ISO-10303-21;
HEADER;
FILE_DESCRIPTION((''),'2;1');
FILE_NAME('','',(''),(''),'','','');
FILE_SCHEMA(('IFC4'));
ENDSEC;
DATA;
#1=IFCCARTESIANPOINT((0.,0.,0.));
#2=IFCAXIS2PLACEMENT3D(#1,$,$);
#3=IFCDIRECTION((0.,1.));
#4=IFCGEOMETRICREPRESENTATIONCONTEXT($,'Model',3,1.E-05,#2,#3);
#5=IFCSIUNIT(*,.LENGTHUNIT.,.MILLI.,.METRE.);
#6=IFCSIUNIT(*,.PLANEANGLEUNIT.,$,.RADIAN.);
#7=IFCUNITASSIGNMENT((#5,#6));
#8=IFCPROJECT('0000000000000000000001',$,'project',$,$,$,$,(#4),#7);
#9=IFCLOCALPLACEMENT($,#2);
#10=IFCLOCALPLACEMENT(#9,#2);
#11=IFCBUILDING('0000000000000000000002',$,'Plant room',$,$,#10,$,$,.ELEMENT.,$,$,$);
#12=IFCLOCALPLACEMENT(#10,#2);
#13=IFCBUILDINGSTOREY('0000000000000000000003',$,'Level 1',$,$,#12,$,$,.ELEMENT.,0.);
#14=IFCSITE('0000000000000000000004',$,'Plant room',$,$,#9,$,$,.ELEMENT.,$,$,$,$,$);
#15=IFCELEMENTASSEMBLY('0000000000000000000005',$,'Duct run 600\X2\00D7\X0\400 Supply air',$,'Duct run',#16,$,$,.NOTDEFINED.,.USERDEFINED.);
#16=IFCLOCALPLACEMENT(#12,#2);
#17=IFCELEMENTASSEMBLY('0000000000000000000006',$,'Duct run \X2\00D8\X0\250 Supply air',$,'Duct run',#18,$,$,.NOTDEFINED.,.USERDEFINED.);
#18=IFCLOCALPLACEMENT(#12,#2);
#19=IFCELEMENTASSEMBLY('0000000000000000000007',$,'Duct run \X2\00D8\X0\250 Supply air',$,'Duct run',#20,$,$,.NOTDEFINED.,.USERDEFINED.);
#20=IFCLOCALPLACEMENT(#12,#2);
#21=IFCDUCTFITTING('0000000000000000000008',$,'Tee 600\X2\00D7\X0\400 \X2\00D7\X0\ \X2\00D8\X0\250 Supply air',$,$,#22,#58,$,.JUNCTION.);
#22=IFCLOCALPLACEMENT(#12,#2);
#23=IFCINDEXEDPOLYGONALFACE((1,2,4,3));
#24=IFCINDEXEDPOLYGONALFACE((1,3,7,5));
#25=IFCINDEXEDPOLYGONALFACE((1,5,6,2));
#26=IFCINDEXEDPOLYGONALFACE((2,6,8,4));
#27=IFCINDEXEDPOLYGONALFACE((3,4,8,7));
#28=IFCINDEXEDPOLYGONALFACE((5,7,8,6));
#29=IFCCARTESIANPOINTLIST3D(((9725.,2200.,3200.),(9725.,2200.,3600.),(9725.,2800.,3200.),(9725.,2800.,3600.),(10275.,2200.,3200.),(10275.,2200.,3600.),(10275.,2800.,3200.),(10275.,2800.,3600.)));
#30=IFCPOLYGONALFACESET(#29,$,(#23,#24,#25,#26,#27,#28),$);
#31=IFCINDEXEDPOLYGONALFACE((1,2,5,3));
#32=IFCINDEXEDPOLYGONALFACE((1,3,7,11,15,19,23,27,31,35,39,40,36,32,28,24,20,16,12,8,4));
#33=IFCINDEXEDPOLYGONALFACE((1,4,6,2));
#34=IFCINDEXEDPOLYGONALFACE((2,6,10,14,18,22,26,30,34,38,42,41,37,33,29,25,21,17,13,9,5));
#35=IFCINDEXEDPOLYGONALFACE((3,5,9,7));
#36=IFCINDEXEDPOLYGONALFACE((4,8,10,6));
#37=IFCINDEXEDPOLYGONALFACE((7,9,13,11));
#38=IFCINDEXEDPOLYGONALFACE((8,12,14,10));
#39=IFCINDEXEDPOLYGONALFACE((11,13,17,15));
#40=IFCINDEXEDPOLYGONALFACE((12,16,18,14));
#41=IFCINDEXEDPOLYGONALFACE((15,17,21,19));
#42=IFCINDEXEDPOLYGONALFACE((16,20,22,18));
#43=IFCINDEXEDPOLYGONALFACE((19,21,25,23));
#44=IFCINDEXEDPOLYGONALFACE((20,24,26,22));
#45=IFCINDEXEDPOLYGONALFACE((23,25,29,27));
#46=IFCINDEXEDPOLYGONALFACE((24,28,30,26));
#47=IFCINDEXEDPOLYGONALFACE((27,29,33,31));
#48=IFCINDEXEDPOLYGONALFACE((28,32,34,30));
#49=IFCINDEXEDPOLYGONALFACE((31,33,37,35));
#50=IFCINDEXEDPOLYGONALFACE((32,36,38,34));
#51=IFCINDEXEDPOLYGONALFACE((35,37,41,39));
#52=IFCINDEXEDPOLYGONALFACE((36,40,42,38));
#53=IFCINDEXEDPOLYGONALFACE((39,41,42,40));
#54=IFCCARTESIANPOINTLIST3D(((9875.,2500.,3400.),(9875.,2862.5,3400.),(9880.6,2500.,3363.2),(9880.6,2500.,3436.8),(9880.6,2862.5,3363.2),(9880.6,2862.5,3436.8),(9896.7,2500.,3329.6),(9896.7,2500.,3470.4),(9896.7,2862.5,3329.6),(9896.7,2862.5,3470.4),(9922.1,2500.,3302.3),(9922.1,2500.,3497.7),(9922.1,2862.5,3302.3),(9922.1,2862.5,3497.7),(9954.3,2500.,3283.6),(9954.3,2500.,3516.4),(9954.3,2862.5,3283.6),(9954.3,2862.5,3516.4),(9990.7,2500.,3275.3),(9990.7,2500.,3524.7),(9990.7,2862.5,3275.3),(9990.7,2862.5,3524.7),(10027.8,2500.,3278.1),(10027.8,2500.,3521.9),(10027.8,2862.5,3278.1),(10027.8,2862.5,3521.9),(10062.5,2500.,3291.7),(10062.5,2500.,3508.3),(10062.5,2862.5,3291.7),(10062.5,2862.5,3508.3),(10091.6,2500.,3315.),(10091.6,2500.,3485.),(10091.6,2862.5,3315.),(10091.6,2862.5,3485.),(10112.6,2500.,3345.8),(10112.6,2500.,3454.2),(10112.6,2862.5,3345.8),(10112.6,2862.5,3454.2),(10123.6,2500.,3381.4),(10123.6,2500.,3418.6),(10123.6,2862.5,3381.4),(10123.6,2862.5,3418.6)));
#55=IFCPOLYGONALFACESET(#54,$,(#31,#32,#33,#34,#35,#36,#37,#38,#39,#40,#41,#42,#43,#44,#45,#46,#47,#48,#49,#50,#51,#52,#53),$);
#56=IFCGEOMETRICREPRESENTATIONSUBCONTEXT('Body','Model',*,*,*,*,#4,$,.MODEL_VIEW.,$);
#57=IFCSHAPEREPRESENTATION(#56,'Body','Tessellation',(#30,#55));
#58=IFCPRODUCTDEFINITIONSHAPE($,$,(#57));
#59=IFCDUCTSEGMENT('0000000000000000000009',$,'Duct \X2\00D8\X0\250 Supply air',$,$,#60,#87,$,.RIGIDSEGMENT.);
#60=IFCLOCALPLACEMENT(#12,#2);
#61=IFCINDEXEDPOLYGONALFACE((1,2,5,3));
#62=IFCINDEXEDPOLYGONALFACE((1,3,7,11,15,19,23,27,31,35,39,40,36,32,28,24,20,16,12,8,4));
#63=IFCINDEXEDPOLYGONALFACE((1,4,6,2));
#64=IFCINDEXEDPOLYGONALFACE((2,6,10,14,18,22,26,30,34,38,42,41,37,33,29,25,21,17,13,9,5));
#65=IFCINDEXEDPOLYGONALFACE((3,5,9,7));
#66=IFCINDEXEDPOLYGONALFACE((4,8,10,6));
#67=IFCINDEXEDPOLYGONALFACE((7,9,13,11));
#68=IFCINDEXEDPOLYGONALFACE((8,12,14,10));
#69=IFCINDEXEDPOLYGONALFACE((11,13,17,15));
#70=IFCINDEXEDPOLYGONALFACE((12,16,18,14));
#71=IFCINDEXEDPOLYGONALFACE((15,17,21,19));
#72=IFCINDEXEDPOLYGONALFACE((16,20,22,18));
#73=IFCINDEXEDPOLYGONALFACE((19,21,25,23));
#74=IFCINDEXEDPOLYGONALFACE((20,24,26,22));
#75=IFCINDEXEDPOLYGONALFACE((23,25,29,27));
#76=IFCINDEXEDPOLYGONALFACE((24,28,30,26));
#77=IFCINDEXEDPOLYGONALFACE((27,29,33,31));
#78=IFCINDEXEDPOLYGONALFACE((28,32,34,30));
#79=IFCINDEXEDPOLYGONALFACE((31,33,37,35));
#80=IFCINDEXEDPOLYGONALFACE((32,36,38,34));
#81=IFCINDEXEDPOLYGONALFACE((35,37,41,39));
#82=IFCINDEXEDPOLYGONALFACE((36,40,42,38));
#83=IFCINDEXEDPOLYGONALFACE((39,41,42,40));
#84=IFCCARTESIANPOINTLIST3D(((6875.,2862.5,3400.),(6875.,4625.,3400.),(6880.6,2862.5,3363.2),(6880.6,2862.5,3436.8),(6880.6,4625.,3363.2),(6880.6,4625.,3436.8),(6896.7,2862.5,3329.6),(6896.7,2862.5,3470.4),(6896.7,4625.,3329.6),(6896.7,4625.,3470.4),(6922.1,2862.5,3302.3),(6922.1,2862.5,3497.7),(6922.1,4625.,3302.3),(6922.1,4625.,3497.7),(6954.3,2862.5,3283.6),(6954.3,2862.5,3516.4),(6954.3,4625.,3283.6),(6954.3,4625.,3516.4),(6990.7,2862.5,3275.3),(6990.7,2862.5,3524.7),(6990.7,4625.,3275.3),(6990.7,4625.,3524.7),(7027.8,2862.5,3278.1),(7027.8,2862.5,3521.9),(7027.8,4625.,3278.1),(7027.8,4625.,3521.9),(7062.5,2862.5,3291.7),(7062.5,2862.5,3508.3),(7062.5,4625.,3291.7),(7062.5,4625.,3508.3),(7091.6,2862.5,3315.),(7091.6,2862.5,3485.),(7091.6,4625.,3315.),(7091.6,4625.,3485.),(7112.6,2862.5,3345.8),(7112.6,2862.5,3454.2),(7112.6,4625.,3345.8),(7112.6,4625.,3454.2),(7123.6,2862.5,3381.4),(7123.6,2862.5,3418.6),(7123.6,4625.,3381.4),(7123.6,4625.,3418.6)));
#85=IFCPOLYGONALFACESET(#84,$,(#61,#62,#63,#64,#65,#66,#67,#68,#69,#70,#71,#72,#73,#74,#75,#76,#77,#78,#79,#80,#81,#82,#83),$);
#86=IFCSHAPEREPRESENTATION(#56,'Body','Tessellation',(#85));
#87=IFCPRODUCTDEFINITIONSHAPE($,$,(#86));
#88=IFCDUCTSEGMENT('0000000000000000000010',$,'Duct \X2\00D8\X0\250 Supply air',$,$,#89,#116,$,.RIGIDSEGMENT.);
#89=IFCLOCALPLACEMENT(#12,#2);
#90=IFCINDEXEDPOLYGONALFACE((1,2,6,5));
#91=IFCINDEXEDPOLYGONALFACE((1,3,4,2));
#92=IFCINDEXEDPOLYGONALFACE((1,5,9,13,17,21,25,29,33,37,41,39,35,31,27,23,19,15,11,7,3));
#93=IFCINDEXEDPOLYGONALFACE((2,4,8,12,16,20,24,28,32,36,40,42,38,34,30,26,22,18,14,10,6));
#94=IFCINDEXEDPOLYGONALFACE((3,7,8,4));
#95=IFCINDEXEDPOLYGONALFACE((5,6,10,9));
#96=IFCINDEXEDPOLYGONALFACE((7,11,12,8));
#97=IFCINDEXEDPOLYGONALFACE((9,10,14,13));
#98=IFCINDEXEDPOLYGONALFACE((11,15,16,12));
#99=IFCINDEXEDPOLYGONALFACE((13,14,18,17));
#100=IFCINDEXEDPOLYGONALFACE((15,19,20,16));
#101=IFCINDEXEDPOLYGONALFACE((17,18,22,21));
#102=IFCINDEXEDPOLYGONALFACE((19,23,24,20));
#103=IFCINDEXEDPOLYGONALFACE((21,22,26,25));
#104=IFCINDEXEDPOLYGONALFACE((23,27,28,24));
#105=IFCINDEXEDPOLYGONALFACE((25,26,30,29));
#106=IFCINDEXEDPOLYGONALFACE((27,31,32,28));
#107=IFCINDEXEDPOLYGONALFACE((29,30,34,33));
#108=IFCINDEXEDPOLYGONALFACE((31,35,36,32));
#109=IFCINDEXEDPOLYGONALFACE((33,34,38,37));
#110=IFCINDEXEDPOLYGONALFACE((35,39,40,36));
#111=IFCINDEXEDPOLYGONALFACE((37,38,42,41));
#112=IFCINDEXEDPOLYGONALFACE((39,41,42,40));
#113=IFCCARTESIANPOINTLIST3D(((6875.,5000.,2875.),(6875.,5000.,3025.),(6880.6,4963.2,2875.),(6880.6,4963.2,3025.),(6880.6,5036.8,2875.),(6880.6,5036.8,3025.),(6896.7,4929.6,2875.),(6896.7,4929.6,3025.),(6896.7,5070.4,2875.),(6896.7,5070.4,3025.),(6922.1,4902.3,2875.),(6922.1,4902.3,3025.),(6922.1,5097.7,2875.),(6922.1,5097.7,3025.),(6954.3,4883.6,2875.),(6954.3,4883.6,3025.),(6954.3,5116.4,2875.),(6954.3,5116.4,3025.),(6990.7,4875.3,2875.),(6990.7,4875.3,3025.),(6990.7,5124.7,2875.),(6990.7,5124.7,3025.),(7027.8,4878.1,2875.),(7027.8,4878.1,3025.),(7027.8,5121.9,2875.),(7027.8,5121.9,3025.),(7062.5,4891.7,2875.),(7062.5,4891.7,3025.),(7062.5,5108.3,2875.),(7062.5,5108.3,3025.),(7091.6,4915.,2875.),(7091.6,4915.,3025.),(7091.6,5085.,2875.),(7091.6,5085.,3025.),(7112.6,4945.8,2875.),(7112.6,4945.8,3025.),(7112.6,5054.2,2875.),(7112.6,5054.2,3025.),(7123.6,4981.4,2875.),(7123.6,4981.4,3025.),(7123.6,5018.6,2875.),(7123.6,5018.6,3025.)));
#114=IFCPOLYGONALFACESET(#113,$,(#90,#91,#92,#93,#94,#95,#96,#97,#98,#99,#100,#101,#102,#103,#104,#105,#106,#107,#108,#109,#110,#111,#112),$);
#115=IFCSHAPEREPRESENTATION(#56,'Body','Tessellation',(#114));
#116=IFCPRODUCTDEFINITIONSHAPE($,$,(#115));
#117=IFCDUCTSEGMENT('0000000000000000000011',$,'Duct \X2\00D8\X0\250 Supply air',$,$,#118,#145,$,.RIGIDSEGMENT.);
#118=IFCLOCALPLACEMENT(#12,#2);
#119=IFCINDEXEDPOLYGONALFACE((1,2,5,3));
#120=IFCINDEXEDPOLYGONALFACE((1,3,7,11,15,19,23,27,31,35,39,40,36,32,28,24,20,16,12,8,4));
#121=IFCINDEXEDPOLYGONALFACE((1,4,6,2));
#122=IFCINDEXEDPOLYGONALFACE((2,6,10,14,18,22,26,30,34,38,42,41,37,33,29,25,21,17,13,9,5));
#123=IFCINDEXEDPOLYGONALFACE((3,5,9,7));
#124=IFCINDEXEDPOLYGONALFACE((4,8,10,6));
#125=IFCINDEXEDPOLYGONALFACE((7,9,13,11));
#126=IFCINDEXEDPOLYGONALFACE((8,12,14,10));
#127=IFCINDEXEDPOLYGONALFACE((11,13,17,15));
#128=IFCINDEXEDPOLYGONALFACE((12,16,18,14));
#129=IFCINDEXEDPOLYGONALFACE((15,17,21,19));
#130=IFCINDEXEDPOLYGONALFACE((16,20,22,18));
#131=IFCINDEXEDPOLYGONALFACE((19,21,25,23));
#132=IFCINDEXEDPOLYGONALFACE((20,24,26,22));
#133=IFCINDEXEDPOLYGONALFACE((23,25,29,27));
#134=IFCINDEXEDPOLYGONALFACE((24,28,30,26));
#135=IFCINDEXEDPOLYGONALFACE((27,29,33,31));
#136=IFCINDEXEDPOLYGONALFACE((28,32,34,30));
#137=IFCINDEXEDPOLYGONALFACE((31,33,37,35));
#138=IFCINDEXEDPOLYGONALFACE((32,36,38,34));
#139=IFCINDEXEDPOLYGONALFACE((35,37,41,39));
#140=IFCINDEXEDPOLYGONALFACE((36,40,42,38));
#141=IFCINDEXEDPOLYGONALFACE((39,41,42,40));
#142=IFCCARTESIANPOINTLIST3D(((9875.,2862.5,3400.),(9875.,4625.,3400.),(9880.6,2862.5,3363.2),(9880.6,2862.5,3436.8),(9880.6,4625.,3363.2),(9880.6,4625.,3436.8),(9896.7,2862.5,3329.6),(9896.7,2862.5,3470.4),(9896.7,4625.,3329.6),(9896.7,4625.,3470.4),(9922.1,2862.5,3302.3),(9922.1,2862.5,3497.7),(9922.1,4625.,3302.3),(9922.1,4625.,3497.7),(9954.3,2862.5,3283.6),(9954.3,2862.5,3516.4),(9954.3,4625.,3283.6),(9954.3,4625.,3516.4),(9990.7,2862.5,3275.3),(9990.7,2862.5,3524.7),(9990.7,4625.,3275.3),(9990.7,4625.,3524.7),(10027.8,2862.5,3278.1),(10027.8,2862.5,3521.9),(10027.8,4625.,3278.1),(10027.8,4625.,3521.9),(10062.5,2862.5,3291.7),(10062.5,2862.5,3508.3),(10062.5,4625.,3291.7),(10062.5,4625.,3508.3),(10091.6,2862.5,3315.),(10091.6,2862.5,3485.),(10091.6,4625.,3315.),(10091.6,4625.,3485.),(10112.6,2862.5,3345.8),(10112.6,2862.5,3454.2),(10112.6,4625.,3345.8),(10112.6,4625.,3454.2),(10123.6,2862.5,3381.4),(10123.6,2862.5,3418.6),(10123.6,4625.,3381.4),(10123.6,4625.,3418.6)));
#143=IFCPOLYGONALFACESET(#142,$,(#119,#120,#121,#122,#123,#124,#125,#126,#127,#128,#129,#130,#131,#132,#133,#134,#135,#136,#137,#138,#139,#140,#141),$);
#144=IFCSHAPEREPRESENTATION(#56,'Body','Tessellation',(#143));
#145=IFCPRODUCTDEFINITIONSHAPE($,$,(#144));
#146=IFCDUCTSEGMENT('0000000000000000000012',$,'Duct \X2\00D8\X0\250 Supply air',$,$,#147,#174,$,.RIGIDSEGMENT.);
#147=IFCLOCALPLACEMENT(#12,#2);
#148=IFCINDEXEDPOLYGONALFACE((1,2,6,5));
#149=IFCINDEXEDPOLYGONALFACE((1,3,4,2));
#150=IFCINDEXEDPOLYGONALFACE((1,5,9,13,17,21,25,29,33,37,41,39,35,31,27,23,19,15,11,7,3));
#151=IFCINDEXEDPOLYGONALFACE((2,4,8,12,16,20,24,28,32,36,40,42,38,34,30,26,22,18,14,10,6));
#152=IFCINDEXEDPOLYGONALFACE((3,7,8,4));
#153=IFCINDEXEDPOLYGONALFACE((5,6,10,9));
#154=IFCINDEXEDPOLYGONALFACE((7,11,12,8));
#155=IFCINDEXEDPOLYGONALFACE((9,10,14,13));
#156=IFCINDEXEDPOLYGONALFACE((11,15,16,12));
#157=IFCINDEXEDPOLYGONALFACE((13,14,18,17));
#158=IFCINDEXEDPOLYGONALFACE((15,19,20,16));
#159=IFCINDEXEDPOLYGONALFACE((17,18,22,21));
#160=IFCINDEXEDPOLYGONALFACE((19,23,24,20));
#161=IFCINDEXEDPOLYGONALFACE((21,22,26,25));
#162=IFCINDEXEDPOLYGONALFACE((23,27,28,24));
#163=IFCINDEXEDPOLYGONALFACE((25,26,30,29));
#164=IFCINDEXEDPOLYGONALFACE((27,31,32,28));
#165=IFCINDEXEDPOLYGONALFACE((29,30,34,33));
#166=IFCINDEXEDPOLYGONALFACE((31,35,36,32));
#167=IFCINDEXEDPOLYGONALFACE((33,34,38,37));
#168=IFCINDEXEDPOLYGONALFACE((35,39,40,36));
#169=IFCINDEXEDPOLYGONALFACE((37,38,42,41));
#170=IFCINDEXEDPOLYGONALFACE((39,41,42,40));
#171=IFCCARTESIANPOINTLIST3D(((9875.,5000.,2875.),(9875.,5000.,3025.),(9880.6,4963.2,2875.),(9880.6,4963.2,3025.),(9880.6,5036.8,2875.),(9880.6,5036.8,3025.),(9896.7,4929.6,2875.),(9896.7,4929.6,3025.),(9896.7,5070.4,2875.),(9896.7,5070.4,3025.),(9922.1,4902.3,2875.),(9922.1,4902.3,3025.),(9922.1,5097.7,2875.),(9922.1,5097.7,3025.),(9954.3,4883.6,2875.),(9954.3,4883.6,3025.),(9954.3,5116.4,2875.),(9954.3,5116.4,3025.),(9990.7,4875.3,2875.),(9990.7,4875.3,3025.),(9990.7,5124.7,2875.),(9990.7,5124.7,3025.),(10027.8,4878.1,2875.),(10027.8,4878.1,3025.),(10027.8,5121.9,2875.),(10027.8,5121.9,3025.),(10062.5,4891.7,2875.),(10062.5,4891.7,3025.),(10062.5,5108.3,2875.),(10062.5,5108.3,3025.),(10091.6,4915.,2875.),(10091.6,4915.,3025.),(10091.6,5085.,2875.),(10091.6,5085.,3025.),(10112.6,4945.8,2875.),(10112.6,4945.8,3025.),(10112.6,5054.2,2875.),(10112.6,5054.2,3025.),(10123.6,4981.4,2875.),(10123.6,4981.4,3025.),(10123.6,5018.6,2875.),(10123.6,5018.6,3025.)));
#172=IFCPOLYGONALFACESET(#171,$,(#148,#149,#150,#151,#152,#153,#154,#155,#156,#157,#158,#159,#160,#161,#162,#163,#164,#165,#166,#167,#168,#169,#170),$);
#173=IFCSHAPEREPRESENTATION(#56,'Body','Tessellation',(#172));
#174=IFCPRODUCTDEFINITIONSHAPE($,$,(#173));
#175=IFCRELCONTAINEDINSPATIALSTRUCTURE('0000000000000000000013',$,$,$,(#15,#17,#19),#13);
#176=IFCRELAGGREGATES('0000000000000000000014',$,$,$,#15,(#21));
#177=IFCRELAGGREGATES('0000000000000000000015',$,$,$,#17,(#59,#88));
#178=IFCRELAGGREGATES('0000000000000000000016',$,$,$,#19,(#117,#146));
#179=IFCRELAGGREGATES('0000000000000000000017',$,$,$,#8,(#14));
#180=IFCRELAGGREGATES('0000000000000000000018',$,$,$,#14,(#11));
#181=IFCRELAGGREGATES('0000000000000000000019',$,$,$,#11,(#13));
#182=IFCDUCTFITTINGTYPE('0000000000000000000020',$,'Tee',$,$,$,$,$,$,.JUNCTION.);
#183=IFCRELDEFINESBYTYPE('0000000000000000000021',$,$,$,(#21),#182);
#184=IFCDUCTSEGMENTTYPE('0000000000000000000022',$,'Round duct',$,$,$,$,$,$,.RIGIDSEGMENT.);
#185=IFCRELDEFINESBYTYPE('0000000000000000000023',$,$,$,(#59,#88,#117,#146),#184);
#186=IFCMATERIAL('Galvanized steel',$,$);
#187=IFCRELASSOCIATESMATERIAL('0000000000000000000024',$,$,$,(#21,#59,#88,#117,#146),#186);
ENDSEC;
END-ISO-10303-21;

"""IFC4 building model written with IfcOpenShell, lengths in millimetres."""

from ifc_helpers import new_model, si_unit, direction, frame, origin, origin_with_axes, origin_2d, place, context, subcontext, project, spatial, rectangle, circle, extrude, material, type_object, element, aggregate, save


model = new_model("IFC4")

# Units and contexts
model_context = context("Model", 3, precision=1e-05, world=origin(), true_north=direction((0.0, 1.0)))
body_context = subcontext(model_context, "Body", "Model", "MODEL_VIEW")
ifc_project = project(units=[si_unit("LENGTHUNIT", "METRE", prefix="MILLI"), si_unit("PLANEANGLEUNIT", "RADIAN")], contexts=[model_context])

# Site, building, storey
site_placement = place(None, origin())
site = spatial("IfcSite", under=ifc_project, at=site_placement, Name="Plant room", CompositionType="ELEMENT")
building_placement = place(site_placement, origin())
building = spatial("IfcBuilding", under=site, at=building_placement, Name="Plant room", CompositionType="ELEMENT")
storey_placement = place(building_placement, origin())
storey = spatial("IfcBuildingStorey", under=building, at=storey_placement, Name="Level 1", CompositionType="ELEMENT", Elevation=0.0)

# Element assembly
assembly_1_placement = place(storey_placement, origin_with_axes())
assembly_1 = element("IfcElementAssembly", 1, at=assembly_1_placement, inside=storey, Name="Duct run 600×400 Supply air", ObjectType="Duct run", AssemblyPlace="NOTDEFINED", PredefinedType="USERDEFINED")
ifc_material_1 = material(Name="Galvanized steel")

# Element assembly
assembly_2_placement = place(storey_placement, origin_with_axes())
assembly_2 = element("IfcElementAssembly", 2, at=assembly_2_placement, inside=storey, Name="Duct run Ø250 Supply air", ObjectType="Duct run", AssemblyPlace="NOTDEFINED", PredefinedType="USERDEFINED")

# Element assembly
assembly_3_placement = place(storey_placement, origin_with_axes())
assembly_3 = element("IfcElementAssembly", 3, at=assembly_3_placement, inside=storey, Name="Duct run Ø250 Supply air", ObjectType="Duct run", AssemblyPlace="NOTDEFINED", PredefinedType="USERDEFINED")

# Duct fitting
duct_fitting_type_1 = type_object("IfcDuctFittingType", Name="Tee", PredefinedType="JUNCTION")
duct_fitting_1_placement = place(storey_placement, origin_with_axes())
duct_fitting_1 = element("IfcDuctFitting", 4, at=duct_fitting_1_placement, type_object=duct_fitting_type_1, material=ifc_material_1, Name="Tee 600×400 × Ø250 Supply air", PredefinedType="JUNCTION", context=body_context, shape_type="SweptSolid", body=[
    extrude(rectangle(XDim=600.0, YDim=400.0, at=origin_2d()), frame((9725.0, 2500.0, 3400.0), z_axis=(1.0, 0.0, 0.0), x_axis=(0.0, 1.0, 0.0)), (0.0, 0.0, 1.0), 550.0),
    extrude(circle(Radius=125.0, at=origin_2d()), frame((10000.0, 2500.0, 3400.0), z_axis=(0.0, 1.0, 0.0), x_axis=(-1.0, 0.0, 0.0)), (0.0, 0.0, 1.0), 362.5),
])
aggregate(assembly_1, [duct_fitting_1])

# Duct segments
duct_segment_type_1 = type_object("IfcDuctSegmentType", Name="Round duct", PredefinedType="RIGIDSEGMENT")
duct_segment_1_placement = place(storey_placement, origin_with_axes())
duct_segment_1 = element("IfcDuctSegment", 5, at=duct_segment_1_placement, type_object=duct_segment_type_1, material=ifc_material_1, Name="Duct Ø250 Supply air", PredefinedType="RIGIDSEGMENT", context=body_context, shape_type="SweptSolid", body=[
    extrude(circle(Radius=125.0, at=origin_2d()), frame((7000.0, 2862.5, 3400.0), z_axis=(0.0, 1.0, 0.0), x_axis=(-1.0, 0.0, 0.0)), (0.0, 0.0, 1.0), 1762.5),
])
duct_segment_2_placement = place(storey_placement, origin_with_axes())
duct_segment_2 = element("IfcDuctSegment", 6, at=duct_segment_2_placement, type_object=duct_segment_type_1, material=ifc_material_1, Name="Duct Ø250 Supply air", PredefinedType="RIGIDSEGMENT", context=body_context, shape_type="SweptSolid", body=[
    extrude(circle(Radius=125.0, at=origin_2d()), frame((7000.0, 5000.0, 3025.0), z_axis=(0.0, 0.0, -1.0), x_axis=(-1.0, 0.0, 0.0)), (0.0, 0.0, 1.0), 150.0),
])
aggregate(assembly_2, [duct_segment_1, duct_segment_2])
duct_segment_3_placement = place(storey_placement, origin_with_axes())
duct_segment_3 = element("IfcDuctSegment", 7, at=duct_segment_3_placement, type_object=duct_segment_type_1, material=ifc_material_1, Name="Duct Ø250 Supply air", PredefinedType="RIGIDSEGMENT", context=body_context, shape_type="SweptSolid", body=[
    extrude(circle(Radius=125.0, at=origin_2d()), frame((10000.0, 2862.5, 3400.0), z_axis=(0.0, 1.0, 0.0), x_axis=(-1.0, 0.0, 0.0)), (0.0, 0.0, 1.0), 1762.5),
])
duct_segment_4_placement = place(storey_placement, origin_with_axes())
duct_segment_4 = element("IfcDuctSegment", 8, at=duct_segment_4_placement, type_object=duct_segment_type_1, material=ifc_material_1, Name="Duct Ø250 Supply air", PredefinedType="RIGIDSEGMENT", context=body_context, shape_type="SweptSolid", body=[
    extrude(circle(Radius=125.0, at=origin_2d()), frame((10000.0, 5000.0, 3025.0), z_axis=(0.0, 0.0, -1.0), x_axis=(-1.0, 0.0, 0.0)), (0.0, 0.0, 1.0), 150.0),
])
aggregate(assembly_3, [duct_segment_3, duct_segment_4])

save(model, "model.ifc")
